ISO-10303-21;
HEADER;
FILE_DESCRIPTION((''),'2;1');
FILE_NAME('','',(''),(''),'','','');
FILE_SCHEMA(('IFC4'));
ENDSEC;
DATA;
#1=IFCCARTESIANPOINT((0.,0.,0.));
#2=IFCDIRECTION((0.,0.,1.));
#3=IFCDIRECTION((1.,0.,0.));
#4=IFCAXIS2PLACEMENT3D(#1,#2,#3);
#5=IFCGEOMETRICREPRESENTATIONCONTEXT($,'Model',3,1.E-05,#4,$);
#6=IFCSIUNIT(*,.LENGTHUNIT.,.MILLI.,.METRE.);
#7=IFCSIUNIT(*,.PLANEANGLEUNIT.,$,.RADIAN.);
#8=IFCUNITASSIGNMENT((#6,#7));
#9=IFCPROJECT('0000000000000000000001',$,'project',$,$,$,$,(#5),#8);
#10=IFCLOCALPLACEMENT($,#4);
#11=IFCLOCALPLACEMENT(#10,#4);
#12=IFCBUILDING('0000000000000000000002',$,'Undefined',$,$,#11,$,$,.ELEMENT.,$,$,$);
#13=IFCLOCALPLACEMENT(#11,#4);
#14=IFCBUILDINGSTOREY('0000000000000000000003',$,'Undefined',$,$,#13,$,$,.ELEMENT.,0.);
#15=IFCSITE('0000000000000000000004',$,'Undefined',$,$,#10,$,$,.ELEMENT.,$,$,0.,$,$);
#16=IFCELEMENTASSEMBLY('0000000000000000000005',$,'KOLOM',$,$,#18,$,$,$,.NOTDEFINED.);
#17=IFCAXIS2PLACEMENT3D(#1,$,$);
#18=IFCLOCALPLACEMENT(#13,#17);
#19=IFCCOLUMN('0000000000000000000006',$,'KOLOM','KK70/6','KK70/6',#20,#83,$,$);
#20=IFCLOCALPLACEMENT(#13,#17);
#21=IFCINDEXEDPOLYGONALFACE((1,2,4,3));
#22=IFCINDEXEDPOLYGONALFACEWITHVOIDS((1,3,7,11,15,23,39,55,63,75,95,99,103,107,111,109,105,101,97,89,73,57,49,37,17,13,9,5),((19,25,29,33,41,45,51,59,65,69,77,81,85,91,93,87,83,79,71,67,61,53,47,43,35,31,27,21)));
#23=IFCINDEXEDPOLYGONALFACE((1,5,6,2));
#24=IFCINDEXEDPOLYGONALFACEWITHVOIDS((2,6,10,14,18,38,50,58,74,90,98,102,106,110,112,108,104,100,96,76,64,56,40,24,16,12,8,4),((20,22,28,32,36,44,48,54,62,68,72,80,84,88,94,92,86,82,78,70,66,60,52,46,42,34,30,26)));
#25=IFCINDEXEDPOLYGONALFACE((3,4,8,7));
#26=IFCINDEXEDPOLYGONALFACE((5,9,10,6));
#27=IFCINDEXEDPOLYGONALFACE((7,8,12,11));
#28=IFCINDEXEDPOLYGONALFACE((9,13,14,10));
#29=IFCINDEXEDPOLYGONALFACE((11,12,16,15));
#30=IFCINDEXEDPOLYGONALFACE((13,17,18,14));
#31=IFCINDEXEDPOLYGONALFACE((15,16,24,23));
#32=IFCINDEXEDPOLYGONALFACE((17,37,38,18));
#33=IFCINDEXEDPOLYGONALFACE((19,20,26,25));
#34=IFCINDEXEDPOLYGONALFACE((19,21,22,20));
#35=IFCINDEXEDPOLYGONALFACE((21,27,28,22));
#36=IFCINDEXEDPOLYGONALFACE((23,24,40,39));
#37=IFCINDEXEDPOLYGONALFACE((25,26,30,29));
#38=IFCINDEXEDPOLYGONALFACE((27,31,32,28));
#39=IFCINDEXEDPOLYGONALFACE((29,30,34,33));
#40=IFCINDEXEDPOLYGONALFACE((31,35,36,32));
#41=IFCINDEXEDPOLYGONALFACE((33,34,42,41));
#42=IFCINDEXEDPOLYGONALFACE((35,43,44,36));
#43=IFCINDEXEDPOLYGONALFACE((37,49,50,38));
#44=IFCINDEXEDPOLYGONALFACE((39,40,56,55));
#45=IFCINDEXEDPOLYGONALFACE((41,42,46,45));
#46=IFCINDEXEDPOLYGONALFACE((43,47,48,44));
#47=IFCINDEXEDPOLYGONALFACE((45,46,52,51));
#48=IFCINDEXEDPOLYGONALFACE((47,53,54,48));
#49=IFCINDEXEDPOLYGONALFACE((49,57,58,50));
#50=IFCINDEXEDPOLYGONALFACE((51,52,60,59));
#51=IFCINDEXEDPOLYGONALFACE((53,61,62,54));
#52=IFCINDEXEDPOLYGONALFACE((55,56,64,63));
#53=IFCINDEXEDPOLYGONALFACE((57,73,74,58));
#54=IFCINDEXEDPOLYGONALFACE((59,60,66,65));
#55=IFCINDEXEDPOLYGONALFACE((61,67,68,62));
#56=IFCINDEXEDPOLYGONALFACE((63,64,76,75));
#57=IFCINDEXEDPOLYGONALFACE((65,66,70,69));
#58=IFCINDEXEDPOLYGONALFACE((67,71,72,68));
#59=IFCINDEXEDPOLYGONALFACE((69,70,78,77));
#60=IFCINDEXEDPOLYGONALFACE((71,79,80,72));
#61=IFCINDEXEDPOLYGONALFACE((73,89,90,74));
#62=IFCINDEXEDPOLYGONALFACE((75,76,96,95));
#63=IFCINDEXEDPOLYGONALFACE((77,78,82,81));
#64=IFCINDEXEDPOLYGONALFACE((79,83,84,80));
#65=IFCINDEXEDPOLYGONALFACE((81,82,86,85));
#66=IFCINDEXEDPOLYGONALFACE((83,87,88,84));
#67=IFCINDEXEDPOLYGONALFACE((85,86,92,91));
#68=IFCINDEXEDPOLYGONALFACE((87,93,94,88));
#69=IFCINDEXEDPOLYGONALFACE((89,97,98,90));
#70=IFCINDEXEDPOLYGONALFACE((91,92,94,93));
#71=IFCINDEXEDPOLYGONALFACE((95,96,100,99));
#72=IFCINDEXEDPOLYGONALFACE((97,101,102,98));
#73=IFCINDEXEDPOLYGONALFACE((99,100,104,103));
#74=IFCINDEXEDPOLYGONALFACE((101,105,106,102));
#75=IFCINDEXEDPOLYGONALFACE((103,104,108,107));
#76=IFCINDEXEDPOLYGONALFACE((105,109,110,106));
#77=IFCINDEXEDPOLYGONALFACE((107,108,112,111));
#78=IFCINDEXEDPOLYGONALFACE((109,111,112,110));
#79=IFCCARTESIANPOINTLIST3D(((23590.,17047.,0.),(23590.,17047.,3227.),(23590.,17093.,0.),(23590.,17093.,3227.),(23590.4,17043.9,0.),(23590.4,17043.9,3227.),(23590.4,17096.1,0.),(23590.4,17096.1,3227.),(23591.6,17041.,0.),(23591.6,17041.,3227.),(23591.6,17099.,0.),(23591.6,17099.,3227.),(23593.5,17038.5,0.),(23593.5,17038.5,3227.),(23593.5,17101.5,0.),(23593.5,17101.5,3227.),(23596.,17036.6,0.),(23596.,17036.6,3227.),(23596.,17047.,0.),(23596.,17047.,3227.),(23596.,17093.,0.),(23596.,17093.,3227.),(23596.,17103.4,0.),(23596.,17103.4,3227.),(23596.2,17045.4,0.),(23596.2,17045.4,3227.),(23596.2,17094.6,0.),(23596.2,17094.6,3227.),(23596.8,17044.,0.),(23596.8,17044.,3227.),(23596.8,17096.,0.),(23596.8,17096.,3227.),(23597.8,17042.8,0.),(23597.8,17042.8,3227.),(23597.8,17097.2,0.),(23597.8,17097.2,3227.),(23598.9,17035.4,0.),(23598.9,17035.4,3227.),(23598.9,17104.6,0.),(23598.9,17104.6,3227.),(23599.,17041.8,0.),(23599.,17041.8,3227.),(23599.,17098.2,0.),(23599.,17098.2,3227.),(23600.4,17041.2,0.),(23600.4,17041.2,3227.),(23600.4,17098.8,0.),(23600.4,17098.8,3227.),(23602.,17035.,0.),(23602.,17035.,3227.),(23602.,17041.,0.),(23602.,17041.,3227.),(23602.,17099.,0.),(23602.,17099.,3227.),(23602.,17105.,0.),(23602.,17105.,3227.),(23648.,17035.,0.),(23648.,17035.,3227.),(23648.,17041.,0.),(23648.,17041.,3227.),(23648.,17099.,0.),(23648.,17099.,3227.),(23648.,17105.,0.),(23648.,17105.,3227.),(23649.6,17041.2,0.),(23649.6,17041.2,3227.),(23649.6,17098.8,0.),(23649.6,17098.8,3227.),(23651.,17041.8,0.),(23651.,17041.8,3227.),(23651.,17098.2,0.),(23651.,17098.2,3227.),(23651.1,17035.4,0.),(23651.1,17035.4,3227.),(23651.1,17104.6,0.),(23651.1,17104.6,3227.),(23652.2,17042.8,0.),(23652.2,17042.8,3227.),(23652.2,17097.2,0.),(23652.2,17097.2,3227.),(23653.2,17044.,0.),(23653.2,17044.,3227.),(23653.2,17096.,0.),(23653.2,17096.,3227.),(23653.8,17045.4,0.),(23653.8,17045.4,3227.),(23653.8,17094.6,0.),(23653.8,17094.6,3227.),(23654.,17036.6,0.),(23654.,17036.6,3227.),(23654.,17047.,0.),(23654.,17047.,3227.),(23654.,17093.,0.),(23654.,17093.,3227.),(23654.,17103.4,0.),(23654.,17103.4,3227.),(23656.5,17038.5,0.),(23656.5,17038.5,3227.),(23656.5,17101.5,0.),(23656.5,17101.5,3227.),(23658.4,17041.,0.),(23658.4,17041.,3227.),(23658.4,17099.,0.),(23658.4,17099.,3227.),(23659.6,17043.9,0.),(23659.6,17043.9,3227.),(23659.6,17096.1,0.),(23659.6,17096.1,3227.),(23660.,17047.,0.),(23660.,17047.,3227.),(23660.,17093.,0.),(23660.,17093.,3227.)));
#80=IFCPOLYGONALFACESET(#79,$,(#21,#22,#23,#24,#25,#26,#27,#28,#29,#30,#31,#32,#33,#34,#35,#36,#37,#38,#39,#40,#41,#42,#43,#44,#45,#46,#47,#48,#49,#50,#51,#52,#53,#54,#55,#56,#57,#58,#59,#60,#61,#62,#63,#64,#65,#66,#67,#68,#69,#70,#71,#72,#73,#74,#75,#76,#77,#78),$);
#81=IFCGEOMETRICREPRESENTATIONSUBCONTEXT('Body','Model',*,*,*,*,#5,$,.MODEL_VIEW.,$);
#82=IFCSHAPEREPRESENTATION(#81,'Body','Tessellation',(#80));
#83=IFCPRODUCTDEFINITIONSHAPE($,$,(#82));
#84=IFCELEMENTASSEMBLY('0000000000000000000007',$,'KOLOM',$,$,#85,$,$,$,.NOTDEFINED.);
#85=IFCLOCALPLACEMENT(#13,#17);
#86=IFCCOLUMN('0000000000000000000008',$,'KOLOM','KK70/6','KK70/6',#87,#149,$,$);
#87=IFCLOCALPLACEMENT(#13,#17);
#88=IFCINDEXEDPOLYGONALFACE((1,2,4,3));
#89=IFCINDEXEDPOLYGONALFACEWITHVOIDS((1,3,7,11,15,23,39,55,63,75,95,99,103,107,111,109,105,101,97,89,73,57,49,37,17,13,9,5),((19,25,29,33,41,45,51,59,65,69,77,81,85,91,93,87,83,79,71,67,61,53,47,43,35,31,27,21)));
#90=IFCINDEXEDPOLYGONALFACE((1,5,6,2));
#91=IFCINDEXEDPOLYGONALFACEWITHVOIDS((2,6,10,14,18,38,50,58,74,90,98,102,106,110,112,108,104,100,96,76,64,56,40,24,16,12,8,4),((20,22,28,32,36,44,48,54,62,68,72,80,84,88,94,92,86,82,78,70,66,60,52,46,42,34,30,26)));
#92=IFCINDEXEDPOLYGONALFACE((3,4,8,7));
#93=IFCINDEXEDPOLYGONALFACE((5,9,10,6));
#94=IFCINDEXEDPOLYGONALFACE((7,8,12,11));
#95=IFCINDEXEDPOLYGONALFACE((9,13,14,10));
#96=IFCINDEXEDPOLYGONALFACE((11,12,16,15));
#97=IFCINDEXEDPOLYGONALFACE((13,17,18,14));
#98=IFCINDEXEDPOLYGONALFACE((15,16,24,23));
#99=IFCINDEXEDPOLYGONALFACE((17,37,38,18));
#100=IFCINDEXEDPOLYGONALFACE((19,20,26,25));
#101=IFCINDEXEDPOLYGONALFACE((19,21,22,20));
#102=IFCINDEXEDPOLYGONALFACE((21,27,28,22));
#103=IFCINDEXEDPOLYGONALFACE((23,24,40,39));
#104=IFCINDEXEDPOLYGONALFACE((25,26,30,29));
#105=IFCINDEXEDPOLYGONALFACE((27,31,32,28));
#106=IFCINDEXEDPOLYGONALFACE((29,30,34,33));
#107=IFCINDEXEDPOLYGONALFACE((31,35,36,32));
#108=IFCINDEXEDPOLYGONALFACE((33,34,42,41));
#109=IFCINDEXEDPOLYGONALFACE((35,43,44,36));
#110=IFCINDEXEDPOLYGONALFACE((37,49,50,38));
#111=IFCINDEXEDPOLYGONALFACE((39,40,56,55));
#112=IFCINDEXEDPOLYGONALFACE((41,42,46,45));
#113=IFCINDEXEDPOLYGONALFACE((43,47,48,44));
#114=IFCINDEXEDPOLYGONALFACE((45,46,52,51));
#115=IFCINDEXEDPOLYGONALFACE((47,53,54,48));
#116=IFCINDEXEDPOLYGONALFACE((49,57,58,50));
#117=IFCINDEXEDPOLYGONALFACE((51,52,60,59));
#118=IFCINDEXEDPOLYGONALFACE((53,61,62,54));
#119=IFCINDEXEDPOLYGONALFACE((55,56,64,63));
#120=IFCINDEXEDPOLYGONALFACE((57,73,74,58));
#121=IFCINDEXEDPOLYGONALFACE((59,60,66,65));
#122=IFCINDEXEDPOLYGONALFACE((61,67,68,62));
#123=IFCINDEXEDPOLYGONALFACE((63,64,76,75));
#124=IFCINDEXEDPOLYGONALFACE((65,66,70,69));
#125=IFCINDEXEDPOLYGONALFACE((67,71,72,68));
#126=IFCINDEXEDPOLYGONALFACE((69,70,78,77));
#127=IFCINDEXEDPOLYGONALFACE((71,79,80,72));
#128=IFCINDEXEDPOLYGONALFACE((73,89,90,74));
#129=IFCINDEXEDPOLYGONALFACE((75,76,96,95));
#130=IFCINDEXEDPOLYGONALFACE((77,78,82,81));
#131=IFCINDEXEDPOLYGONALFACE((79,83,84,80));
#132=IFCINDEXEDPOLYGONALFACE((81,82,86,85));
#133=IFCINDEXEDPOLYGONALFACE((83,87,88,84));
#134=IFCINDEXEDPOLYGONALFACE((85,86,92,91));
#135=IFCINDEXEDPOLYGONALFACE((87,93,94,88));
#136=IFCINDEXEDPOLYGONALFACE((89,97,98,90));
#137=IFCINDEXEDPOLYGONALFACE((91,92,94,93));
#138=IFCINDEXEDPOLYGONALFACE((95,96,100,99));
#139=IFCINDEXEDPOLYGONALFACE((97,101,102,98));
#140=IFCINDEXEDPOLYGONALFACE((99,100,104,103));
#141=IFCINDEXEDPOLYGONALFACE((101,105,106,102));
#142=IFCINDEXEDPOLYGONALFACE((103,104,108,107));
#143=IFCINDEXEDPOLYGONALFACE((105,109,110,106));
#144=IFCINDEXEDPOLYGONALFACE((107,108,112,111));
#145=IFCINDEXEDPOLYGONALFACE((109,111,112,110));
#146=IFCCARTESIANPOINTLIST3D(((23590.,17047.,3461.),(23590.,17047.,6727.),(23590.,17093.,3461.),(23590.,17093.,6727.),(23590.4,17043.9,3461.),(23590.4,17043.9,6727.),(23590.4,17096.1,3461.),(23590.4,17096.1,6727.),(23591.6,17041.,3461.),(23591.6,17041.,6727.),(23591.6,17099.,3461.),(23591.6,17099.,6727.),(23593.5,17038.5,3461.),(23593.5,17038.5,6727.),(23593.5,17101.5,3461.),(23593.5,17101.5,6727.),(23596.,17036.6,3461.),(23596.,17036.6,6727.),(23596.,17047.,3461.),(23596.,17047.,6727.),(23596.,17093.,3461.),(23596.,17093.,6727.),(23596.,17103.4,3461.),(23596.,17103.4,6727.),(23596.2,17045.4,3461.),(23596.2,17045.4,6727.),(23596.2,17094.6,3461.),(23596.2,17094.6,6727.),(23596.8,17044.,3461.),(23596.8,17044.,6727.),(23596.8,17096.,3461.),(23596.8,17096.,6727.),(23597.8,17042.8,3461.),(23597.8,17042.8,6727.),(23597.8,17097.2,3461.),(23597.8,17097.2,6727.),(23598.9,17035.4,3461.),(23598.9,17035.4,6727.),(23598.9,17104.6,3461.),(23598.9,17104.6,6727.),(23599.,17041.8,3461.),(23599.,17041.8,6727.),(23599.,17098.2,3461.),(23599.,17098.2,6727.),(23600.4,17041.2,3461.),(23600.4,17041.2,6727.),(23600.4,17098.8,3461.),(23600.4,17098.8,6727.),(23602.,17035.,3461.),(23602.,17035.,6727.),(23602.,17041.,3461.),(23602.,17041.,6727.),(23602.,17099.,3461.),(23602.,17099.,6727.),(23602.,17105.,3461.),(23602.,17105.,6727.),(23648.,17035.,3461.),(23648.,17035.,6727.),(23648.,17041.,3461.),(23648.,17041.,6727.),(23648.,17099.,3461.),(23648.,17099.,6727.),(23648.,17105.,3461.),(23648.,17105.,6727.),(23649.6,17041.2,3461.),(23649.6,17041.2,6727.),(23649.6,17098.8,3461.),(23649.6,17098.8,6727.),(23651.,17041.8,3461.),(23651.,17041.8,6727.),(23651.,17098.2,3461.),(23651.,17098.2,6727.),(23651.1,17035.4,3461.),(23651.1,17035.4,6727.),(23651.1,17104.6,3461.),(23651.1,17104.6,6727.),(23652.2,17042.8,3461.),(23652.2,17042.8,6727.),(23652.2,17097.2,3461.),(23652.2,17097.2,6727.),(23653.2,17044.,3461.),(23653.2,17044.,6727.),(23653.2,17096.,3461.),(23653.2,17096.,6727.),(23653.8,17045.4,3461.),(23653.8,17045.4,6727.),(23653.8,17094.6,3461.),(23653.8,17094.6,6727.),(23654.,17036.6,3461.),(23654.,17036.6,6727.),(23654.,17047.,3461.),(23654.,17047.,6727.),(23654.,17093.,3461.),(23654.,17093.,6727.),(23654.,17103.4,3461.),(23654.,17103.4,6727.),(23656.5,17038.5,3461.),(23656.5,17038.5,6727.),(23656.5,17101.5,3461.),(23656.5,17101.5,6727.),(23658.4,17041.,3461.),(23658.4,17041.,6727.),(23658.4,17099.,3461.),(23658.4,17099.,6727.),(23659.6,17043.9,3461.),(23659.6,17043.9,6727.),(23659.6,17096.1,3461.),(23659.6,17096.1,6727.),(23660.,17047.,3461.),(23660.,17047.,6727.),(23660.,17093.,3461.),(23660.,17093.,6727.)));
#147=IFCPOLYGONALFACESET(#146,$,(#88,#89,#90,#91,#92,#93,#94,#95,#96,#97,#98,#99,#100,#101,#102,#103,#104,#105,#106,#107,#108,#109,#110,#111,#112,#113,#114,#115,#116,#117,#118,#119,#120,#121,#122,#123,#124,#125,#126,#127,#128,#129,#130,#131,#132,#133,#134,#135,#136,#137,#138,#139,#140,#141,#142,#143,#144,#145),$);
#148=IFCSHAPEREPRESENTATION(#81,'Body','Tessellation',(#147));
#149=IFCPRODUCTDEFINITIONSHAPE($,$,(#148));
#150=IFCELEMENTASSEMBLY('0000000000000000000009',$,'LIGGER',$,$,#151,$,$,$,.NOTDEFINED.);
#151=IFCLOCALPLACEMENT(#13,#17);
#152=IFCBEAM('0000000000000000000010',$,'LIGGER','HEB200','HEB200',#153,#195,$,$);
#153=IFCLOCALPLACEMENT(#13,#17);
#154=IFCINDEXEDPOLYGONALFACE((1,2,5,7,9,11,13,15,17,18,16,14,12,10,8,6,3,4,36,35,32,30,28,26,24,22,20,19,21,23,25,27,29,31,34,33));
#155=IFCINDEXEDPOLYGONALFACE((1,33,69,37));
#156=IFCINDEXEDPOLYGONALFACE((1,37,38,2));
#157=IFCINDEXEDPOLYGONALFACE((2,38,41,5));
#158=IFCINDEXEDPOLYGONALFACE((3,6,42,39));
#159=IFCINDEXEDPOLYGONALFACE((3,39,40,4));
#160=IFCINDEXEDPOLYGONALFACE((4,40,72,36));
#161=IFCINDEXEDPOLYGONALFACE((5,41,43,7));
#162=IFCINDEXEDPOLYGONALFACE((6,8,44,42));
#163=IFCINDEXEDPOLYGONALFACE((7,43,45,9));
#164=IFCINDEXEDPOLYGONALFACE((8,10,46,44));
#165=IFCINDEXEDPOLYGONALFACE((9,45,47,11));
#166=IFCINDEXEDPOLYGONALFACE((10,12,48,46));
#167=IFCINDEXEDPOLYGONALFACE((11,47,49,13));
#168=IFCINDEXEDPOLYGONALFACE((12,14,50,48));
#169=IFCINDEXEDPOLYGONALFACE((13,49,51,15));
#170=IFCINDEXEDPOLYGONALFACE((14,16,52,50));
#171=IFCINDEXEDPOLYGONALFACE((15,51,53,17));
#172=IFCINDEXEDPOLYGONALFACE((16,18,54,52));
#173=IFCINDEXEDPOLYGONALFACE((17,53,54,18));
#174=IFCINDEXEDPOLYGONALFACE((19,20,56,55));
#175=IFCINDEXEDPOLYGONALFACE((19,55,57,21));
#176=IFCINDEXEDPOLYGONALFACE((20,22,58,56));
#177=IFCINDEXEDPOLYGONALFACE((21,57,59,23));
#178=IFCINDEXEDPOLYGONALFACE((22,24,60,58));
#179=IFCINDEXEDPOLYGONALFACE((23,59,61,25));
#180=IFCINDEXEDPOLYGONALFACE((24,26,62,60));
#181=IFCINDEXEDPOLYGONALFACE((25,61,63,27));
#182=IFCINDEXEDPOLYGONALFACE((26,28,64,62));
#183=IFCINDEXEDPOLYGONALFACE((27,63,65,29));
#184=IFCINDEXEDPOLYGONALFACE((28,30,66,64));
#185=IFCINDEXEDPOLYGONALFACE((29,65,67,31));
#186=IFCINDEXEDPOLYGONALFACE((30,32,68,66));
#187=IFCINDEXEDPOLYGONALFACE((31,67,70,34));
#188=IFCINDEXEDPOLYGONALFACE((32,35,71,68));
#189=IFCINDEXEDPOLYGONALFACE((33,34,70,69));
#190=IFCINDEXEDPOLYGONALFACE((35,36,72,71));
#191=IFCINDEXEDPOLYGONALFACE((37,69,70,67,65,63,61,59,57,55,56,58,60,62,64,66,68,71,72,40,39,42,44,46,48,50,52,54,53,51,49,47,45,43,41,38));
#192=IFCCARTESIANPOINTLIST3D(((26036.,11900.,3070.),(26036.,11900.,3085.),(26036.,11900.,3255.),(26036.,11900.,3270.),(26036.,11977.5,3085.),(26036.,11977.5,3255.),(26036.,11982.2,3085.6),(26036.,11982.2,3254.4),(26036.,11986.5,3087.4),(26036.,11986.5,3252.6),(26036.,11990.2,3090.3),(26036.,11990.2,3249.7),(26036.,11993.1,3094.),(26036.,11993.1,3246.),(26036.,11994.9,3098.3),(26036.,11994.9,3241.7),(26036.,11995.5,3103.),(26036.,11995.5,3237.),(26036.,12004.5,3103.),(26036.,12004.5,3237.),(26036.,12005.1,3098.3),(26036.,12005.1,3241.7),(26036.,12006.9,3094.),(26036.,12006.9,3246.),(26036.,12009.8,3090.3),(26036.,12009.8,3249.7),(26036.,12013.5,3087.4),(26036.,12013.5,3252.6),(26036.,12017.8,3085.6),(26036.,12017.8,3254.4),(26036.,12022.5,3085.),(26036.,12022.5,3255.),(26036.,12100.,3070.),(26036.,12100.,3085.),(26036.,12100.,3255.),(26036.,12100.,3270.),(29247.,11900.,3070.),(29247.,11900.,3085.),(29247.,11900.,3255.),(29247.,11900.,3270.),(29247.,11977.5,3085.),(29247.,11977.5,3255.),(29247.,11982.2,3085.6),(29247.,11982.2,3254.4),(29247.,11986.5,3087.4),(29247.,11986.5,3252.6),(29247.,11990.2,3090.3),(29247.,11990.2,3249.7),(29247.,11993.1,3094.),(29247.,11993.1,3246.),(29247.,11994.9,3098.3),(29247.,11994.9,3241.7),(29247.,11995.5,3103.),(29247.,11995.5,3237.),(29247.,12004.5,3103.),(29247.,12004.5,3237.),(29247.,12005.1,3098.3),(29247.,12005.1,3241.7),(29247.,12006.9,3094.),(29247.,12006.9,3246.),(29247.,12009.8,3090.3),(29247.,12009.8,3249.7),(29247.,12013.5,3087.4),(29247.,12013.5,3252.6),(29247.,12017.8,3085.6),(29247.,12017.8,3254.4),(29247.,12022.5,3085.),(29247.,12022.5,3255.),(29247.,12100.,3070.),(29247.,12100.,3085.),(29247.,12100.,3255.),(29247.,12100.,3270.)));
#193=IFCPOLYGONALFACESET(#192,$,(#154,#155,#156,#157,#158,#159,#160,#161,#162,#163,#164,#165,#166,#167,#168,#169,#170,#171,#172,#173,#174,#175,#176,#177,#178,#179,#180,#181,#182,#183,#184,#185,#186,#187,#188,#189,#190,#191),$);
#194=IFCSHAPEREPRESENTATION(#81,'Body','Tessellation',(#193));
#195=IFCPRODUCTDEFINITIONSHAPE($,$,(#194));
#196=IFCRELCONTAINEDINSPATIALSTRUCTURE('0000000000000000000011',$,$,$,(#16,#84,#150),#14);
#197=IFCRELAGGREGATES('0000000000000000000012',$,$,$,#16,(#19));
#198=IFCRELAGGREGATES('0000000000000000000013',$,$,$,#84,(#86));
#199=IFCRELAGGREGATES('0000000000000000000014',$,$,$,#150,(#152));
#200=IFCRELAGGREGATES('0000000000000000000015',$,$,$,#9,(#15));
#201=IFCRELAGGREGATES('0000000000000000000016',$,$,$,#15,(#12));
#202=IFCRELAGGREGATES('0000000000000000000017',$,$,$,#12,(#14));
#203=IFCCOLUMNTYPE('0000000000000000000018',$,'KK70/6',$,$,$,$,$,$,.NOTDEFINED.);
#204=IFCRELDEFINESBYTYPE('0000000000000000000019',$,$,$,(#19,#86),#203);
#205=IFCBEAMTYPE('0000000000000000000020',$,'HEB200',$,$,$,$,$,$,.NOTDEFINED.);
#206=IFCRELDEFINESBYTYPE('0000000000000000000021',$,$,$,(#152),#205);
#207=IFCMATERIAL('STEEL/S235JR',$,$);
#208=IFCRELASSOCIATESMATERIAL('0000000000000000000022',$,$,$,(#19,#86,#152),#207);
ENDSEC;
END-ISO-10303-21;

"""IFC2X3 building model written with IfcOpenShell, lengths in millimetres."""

from ifc_helpers import new_model, si_unit, frame, origin_with_axes, origin_2d_with_axis, place, context, subcontext, project, spatial, hollow_rectangle, i_section, extrude, material, type_object, element, aggregate, save


model = new_model("IFC2X3")

# Units and contexts
model_context = context("Model", 3, precision=1e-05, world=origin_with_axes())
body_context = subcontext(model_context, "Body", "Model", "MODEL_VIEW")
ifc_project = project(units=[si_unit("LENGTHUNIT", "METRE", prefix="MILLI"), si_unit("PLANEANGLEUNIT", "RADIAN")], contexts=[model_context])

# Site, building, storey
site_placement = place(None, origin_with_axes())
site = spatial("IfcSite", under=ifc_project, at=site_placement, Name="Undefined", CompositionType="ELEMENT", RefElevation=0.0)
building_placement = place(site_placement, origin_with_axes())
building = spatial("IfcBuilding", under=site, at=building_placement, Name="Undefined", CompositionType="ELEMENT")
storey_placement = place(building_placement, origin_with_axes())
storey = spatial("IfcBuildingStorey", under=building, at=storey_placement, Name="Undefined", CompositionType="ELEMENT", Elevation=0.0)

# Element assemblies, columns
assembly_1_placement = place(storey_placement, origin_with_axes())
assembly_1 = element("IfcElementAssembly", 1, at=assembly_1_placement, inside=storey, Name="KOLOM", PredefinedType="NOTDEFINED")
ifc_material = material(Name="STEEL/S235JR")
column_type = type_object("IfcColumnType", Name="KK70/6", PredefinedType="NOTDEFINED")
column_1_placement = place(assembly_1_placement, frame((23625.0, 17070.0, 0.0), z_axis=(0.0, 0.0, 1.0), x_axis=(1.0, 0.0, 0.0)))
column_1 = element("IfcColumn", 2, at=column_1_placement, type_object=column_type, material=ifc_material, Name="KOLOM", Description="KK70/6", ObjectType="KK70/6", context=body_context, shape_type="SweptSolid", body=[
    extrude(hollow_rectangle(XDim=70.0, YDim=70.0, WallThickness=6.0, InnerFilletRadius=6.0, OuterFilletRadius=12.0, at=origin_2d_with_axis()), frame((0.0, 0.0, 3227.0), z_axis=(0.0, 0.0, -1.0), x_axis=(0.0, -1.0, 0.0)), (0.0, 0.0, 1.0), 3227.0),
])
assembly_2_placement = place(storey_placement, origin_with_axes())
assembly_2 = element("IfcElementAssembly", 3, at=assembly_2_placement, inside=storey, Name="KOLOM", PredefinedType="NOTDEFINED")
column_2_placement = place(assembly_2_placement, frame((23625.0, 17070.0, 3450.0), z_axis=(0.0, 0.0, 1.0), x_axis=(1.0, 0.0, 0.0)))
column_2 = element("IfcColumn", 4, at=column_2_placement, type_object=column_type, material=ifc_material, Name="KOLOM", Description="KK70/6", ObjectType="KK70/6", context=body_context, shape_type="SweptSolid", body=[
    extrude(hollow_rectangle(XDim=70.0, YDim=70.0, WallThickness=6.0, InnerFilletRadius=6.0, OuterFilletRadius=12.0, at=origin_2d_with_axis()), frame((0.0, 0.0, 3277.0), z_axis=(0.0, 0.0, -1.0), x_axis=(0.0, -1.0, 0.0)), (0.0, 0.0, 1.0), 3266.0),
])

# Element assembly, beam
assembly_3_placement = place(storey_placement, origin_with_axes())
assembly_3 = element("IfcElementAssembly", 5, at=assembly_3_placement, inside=storey, Name="LIGGER", PredefinedType="NOTDEFINED")
beam_type_1 = type_object("IfcBeamType", Name="HEB200", PredefinedType="NOTDEFINED")
beam_1_placement = place(assembly_3_placement, frame((25875.0, 12000.0, 3170.0), z_axis=(0.0, 0.0, 1.0), x_axis=(1.0, 0.0, 0.0)))
beam_1 = element("IfcBeam", 6, at=beam_1_placement, type_object=beam_type_1, material=ifc_material, Name="LIGGER", Description="HEB200", ObjectType="HEB200", context=body_context, shape_type="SweptSolid", body=[
    extrude(i_section(OverallWidth=200.0, OverallDepth=200.0, WebThickness=9.0, FlangeThickness=15.0, FilletRadius=18.0, at=origin_2d_with_axis()), frame((3372.0, 0.0, 0.0), z_axis=(-1.0, 0.0, 0.0), x_axis=(0.0, -1.0, 0.0)), (0.0, 0.0, 1.0), 3211.0),
])

aggregate(assembly_1, [column_1])
aggregate(assembly_2, [column_2])
aggregate(assembly_3, [beam_1])

save(model, "model.ifc")
